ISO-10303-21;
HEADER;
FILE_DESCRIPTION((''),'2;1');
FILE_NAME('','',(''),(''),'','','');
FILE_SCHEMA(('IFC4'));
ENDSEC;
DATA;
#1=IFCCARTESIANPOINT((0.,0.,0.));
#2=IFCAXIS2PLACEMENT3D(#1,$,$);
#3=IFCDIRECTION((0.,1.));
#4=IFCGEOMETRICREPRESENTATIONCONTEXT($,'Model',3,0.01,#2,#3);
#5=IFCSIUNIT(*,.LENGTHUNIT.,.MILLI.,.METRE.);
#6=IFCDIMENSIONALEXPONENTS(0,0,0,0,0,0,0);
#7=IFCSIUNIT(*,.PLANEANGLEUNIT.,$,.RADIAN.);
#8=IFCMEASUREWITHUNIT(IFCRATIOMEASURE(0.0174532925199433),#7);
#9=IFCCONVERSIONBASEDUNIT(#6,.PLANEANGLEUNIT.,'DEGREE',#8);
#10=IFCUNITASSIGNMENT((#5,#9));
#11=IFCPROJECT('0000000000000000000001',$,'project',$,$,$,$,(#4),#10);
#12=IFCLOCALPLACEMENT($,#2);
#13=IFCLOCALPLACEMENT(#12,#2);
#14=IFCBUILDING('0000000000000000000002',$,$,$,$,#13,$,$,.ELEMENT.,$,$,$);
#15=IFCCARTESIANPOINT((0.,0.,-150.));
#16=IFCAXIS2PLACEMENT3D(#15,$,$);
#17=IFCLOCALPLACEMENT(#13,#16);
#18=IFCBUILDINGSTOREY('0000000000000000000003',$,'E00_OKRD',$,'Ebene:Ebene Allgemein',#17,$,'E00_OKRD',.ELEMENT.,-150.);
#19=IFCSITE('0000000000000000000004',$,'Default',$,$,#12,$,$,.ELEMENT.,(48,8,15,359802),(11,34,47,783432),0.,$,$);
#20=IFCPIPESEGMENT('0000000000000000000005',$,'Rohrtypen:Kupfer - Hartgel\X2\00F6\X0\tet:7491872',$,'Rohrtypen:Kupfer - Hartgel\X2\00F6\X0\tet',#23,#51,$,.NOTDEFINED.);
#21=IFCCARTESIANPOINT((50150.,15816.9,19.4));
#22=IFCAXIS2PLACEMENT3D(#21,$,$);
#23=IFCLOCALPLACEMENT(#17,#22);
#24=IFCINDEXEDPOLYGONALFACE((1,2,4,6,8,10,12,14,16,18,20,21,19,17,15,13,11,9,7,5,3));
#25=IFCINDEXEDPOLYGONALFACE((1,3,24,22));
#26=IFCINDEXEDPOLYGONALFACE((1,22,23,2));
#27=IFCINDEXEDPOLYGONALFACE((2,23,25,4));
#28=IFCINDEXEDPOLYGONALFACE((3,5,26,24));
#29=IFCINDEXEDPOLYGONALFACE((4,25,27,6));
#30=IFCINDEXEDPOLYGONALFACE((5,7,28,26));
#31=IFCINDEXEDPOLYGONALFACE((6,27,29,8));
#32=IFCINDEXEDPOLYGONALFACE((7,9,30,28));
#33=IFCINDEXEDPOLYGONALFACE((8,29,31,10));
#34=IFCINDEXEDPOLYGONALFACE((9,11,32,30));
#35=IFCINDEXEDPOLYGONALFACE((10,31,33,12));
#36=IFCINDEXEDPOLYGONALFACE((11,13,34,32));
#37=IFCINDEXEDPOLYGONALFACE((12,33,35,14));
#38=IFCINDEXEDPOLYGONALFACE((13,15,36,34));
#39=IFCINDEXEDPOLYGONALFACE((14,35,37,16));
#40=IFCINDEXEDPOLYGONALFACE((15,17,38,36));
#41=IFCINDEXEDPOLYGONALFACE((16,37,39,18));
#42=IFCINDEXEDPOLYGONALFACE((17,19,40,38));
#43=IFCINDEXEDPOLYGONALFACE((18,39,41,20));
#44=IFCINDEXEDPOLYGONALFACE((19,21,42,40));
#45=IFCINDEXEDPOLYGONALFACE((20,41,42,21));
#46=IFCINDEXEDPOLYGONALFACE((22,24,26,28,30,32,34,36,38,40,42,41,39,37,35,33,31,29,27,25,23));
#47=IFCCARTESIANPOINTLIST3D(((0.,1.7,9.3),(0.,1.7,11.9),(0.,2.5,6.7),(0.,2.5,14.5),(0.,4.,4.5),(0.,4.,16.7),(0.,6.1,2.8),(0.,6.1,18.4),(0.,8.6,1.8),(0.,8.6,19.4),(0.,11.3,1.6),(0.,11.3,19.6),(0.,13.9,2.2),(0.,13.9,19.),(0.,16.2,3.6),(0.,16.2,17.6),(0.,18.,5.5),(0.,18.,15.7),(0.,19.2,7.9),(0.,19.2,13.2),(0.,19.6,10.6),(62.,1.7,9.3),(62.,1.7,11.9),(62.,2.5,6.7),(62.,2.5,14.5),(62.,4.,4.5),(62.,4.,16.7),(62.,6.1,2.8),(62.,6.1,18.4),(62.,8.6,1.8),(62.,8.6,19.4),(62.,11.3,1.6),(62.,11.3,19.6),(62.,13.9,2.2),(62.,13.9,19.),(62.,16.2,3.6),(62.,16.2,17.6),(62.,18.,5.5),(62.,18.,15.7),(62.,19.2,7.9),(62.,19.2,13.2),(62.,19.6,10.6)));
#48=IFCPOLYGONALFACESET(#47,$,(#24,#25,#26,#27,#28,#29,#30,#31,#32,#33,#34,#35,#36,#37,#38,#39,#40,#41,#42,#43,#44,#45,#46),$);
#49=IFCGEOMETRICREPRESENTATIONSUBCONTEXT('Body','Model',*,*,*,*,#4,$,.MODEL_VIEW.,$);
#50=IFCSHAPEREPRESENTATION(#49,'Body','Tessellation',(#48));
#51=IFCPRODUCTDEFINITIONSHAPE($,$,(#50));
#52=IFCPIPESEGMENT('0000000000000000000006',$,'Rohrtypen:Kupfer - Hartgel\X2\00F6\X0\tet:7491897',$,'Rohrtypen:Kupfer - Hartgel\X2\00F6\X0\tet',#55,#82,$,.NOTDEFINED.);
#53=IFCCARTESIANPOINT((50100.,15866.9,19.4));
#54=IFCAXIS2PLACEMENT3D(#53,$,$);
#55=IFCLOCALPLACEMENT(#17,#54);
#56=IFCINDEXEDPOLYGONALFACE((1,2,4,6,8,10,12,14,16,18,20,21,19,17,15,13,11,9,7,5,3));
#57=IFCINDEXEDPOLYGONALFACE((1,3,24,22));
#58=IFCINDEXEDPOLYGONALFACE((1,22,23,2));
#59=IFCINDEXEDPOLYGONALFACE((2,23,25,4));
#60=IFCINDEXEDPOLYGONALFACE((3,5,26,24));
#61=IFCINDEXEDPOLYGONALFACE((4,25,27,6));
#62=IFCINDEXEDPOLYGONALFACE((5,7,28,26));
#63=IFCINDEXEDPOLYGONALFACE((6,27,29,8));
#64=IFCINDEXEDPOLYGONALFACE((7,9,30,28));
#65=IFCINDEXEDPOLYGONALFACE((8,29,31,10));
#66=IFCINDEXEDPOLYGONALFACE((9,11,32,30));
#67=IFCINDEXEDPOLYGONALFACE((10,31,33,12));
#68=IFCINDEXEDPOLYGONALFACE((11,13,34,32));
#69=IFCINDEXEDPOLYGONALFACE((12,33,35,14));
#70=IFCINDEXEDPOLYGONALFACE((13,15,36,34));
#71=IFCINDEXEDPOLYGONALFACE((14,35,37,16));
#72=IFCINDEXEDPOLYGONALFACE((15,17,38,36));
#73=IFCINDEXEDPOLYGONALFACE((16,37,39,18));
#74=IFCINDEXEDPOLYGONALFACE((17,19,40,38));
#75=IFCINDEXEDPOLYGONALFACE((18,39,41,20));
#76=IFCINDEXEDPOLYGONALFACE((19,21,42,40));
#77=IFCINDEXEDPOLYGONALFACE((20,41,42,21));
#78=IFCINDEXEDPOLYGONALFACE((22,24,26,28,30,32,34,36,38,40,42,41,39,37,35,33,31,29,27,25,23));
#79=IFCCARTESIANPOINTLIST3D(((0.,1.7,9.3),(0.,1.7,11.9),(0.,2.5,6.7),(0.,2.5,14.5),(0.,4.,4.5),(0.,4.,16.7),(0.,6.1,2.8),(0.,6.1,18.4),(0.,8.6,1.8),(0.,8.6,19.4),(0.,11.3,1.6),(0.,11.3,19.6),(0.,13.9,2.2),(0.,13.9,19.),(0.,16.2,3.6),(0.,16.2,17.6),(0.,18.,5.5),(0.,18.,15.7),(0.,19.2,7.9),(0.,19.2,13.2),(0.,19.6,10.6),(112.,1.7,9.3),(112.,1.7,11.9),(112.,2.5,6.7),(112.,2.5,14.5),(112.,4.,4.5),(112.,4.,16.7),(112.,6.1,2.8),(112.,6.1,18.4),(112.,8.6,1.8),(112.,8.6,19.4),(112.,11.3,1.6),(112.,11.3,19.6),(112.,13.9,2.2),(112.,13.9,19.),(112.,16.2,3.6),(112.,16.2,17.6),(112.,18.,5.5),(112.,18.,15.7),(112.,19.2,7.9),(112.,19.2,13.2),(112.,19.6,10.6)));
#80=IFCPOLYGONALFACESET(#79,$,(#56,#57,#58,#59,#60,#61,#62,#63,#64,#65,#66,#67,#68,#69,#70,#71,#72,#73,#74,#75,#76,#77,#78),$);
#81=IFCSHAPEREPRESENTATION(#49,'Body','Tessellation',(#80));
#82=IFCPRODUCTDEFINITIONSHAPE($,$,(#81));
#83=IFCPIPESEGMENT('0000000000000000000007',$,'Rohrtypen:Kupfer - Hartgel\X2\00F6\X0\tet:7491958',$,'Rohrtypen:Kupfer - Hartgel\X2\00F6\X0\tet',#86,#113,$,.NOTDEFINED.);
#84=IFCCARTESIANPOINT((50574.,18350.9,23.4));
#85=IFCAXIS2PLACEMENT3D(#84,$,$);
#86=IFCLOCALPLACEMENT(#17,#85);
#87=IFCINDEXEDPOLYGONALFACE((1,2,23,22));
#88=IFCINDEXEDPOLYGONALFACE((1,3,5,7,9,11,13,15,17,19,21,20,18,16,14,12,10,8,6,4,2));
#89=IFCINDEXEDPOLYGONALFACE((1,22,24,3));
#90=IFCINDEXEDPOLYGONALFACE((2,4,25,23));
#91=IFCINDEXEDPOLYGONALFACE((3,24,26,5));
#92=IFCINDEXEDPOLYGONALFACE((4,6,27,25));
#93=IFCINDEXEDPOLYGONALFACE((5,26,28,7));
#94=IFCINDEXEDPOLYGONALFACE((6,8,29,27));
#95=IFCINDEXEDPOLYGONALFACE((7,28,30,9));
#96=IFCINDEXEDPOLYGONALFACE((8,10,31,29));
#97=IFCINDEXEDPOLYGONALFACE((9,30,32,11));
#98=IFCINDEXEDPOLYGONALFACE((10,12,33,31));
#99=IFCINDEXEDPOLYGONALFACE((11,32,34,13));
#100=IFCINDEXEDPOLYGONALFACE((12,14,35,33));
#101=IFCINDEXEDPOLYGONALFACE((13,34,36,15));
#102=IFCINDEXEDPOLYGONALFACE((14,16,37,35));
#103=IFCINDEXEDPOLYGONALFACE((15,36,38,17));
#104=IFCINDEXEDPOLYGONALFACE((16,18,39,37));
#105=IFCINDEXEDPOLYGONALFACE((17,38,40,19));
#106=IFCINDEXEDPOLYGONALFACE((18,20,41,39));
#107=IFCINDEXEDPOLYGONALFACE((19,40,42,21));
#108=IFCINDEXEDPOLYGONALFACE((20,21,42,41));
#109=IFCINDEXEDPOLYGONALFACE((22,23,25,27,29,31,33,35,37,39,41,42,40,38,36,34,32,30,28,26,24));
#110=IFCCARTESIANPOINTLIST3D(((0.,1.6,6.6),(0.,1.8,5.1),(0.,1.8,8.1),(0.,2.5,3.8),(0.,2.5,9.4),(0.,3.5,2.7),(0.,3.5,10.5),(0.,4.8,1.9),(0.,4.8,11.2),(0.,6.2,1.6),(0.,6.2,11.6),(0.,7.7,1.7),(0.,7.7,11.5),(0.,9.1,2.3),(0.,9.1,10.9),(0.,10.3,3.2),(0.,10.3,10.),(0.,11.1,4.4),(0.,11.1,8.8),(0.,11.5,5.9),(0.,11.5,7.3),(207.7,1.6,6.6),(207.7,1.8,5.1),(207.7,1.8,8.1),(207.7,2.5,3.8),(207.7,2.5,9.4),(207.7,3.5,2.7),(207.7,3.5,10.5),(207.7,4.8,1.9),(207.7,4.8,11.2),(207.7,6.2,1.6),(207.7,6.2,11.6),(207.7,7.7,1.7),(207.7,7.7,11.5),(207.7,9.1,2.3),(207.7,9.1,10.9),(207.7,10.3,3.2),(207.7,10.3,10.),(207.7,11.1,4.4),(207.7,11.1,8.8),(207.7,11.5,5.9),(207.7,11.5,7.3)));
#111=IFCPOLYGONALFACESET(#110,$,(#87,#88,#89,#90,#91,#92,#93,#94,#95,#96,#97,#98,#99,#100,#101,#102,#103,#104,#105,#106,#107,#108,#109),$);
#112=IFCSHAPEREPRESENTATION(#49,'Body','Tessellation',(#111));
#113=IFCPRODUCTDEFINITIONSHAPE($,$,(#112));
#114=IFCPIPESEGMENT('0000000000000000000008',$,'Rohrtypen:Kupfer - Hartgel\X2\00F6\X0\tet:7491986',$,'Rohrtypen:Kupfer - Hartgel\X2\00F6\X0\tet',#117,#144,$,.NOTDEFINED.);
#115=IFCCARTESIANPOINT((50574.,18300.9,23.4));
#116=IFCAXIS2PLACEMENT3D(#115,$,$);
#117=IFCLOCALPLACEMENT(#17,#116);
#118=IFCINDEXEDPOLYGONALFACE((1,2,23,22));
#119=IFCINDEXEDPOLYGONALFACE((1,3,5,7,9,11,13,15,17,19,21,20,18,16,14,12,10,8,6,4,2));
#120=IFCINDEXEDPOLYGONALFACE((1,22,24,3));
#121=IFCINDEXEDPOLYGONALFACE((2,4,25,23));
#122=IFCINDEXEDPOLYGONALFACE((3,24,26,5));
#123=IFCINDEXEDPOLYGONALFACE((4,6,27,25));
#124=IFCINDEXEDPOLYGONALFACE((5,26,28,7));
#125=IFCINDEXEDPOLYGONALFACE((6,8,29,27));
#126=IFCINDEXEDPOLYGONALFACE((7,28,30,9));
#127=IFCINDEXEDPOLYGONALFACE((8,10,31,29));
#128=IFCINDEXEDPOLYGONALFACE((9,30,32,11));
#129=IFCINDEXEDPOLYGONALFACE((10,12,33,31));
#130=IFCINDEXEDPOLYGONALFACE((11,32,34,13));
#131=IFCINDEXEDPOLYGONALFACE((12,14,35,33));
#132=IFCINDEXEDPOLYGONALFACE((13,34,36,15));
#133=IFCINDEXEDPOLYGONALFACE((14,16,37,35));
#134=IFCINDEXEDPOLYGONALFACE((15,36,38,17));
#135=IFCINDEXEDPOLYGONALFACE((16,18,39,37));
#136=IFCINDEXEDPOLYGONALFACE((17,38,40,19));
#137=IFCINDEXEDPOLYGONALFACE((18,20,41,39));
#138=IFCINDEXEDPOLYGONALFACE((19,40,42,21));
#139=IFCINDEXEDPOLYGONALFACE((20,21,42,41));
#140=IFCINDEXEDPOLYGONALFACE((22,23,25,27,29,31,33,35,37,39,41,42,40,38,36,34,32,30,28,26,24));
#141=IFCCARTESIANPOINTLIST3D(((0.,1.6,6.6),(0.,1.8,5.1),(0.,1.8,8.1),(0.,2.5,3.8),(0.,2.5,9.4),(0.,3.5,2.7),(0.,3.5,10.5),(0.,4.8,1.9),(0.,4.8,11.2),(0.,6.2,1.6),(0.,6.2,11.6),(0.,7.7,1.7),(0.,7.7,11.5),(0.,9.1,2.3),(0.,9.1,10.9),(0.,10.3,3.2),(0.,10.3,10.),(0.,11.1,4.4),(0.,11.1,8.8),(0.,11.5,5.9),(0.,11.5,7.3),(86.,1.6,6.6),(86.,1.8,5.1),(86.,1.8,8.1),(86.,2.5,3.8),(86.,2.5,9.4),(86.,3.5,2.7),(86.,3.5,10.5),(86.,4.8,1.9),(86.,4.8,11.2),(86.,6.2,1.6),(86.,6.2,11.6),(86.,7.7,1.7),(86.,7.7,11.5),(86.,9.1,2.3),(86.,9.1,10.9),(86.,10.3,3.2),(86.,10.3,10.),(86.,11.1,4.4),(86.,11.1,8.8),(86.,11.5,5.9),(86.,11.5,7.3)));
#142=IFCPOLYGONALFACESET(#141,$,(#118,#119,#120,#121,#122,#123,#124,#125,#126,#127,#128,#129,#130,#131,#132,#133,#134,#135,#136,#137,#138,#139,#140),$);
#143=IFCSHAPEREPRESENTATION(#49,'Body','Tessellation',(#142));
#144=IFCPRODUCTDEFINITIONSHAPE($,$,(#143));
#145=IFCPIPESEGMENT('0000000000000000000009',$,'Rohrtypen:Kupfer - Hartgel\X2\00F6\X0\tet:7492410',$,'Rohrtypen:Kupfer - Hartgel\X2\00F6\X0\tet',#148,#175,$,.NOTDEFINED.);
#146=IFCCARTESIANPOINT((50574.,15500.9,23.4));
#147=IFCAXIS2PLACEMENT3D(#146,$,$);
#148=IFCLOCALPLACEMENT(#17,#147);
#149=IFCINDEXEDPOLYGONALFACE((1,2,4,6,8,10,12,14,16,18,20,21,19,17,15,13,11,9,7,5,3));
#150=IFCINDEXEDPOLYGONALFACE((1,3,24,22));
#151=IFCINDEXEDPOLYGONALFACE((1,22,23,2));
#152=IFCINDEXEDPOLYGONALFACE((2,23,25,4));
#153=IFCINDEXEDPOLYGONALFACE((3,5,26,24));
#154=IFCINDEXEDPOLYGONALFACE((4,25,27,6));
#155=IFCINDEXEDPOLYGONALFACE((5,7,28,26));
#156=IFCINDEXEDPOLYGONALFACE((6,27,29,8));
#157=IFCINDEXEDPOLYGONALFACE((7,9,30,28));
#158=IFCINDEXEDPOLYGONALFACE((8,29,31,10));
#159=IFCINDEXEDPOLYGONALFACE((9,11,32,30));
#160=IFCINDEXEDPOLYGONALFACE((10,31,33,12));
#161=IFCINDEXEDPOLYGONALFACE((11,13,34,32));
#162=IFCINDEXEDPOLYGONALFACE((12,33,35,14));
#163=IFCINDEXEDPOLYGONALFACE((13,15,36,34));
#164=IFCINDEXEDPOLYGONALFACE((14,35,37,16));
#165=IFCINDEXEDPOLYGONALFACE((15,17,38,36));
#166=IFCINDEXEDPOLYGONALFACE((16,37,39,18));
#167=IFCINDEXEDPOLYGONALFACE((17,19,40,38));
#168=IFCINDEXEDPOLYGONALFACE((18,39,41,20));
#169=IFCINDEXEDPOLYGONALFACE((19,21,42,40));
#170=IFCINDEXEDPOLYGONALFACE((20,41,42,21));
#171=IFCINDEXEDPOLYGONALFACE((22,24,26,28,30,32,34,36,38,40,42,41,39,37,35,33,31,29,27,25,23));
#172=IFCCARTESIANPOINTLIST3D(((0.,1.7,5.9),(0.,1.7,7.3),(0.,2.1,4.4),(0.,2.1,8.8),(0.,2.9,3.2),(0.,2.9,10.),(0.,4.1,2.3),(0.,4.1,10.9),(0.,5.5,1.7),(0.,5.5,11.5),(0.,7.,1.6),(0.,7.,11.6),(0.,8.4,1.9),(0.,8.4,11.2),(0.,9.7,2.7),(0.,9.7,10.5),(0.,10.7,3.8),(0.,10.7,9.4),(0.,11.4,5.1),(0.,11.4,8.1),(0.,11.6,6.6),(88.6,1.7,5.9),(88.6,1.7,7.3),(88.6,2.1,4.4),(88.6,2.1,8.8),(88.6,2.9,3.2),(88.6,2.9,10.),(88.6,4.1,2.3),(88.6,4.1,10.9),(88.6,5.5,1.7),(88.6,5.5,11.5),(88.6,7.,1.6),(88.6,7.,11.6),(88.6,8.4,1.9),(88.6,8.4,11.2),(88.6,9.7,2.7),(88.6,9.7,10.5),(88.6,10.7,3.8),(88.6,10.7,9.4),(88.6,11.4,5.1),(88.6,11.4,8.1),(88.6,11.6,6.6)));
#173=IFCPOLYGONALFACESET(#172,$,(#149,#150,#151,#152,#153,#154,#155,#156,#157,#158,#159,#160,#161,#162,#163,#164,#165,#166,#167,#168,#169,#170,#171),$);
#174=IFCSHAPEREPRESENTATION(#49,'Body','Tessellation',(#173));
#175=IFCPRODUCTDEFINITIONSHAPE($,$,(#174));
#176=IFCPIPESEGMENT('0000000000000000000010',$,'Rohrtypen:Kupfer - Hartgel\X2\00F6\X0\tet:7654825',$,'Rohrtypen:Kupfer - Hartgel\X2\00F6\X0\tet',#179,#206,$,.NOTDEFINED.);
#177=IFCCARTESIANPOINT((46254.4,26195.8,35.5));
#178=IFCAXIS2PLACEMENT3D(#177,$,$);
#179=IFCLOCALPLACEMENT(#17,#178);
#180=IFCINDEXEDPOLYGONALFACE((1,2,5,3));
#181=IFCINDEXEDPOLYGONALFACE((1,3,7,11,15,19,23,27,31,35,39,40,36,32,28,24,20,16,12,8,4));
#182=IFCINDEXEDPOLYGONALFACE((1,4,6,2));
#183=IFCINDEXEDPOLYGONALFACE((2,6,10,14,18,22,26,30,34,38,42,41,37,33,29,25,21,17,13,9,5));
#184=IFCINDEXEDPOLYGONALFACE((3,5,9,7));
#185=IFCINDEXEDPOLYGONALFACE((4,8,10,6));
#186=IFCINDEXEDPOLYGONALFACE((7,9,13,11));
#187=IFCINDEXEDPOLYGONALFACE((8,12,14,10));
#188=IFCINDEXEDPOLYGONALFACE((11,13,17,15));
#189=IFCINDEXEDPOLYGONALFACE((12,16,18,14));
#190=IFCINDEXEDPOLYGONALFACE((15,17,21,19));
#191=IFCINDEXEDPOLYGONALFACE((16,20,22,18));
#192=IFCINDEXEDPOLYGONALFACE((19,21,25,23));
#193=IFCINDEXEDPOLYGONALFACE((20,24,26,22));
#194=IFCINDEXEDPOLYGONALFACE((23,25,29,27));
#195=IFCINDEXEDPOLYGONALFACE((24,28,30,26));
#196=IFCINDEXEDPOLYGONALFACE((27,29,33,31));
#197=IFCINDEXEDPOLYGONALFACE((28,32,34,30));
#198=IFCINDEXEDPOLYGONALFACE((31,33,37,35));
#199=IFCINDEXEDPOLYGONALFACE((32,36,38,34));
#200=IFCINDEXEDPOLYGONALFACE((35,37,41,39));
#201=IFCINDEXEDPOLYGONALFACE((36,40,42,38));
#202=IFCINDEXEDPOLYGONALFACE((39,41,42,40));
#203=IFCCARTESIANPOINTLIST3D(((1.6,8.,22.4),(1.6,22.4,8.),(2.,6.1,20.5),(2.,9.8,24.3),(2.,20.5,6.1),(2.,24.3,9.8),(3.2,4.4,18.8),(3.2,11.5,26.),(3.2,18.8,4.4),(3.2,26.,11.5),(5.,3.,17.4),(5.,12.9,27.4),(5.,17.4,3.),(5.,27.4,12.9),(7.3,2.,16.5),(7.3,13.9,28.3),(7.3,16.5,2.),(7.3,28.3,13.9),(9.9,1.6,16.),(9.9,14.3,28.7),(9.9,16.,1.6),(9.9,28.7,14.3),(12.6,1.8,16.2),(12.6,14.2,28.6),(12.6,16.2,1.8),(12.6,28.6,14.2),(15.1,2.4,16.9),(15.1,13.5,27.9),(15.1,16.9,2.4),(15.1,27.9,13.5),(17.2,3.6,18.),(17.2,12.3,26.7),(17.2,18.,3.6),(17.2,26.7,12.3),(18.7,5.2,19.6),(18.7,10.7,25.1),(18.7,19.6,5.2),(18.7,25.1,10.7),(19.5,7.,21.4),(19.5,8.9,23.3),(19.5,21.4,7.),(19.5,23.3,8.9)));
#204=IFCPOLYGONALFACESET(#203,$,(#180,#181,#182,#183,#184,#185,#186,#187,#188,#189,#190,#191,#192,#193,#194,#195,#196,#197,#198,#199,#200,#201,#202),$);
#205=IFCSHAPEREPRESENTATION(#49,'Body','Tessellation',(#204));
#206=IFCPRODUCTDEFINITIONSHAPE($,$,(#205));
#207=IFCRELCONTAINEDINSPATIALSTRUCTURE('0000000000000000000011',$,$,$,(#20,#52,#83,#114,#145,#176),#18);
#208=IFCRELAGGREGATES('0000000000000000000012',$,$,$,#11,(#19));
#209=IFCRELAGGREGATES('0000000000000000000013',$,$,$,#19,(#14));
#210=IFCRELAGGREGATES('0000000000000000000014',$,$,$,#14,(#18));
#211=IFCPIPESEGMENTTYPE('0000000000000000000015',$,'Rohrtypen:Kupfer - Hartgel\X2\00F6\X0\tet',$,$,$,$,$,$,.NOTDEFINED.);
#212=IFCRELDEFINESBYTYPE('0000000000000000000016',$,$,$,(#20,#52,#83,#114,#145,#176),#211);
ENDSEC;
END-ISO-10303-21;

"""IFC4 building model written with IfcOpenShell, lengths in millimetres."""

from ifc_helpers import new_model, entity, si_unit, converted_unit, direction, frame, frame_2d, origin, origin_2d_with_axis, place, context, subcontext, project, spatial, circle, extrude, type_object, element, save


model = new_model("IFC4")

# Units and contexts
model_context = context("Model", 3, precision=0.01, world=origin(), true_north=direction((0.0, 1.0)))
body_context = subcontext(model_context, "Body", "Model", "MODEL_VIEW")
ifc_project = project(units=[si_unit("LENGTHUNIT", "METRE", prefix="MILLI"), converted_unit("PLANEANGLEUNIT", "DEGREE", entity("IfcRatioMeasure", 0.0174532925199433), si_unit("PLANEANGLEUNIT", "RADIAN"), dimensions=[0, 0, 0, 0, 0, 0, 0])], contexts=[model_context])

# Site, building, storey
site_placement = place(None, origin())
site = spatial("IfcSite", under=ifc_project, at=site_placement, Name="Default", CompositionType="ELEMENT", RefLatitude=(48, 8, 15, 359802), RefLongitude=(11, 34, 47, 783432), RefElevation=0.0)
building_placement = place(site_placement, origin())
building = spatial("IfcBuilding", under=site, at=building_placement, CompositionType="ELEMENT")
storey_placement = place(building_placement, frame((0.0, 0.0, -150.0)))
storey = spatial("IfcBuildingStorey", under=building, at=storey_placement, Name="E00_OKRD", ObjectType="Ebene:Ebene Allgemein", LongName="E00_OKRD", CompositionType="ELEMENT", Elevation=-150.0)

# Pipe segments
pipe_segment_type = type_object("IfcPipeSegmentType", Name="Rohrtypen:Kupfer - Hartgelötet", PredefinedType="NOTDEFINED")
pipe_segment_1_placement = place(storey_placement, frame((50150.0, 15816.9, 19.4)))
element("IfcPipeSegment", 1, at=pipe_segment_1_placement, inside=storey, type_object=pipe_segment_type, Name="Rohrtypen:Kupfer - Hartgelötet:7491872", ObjectType="Rohrtypen:Kupfer - Hartgelötet", PredefinedType="NOTDEFINED", context=body_context, shape_type="SweptSolid", body=[
    extrude(circle(Radius=9.0, at=frame_2d((0.0, 0.0), x_axis=(1.0, 0.0))), frame((0.0, 10.6, 10.6), z_axis=(1.0, 0.0, 0.0), x_axis=(0.0, 1.0, 0.0)), (0.0, 0.0, 1.0), 62.0),
])
pipe_segment_2_placement = place(storey_placement, frame((50100.0, 15866.9, 19.4)))
element("IfcPipeSegment", 2, at=pipe_segment_2_placement, inside=storey, type_object=pipe_segment_type, Name="Rohrtypen:Kupfer - Hartgelötet:7491897", ObjectType="Rohrtypen:Kupfer - Hartgelötet", PredefinedType="NOTDEFINED", context=body_context, shape_type="SweptSolid", body=[
    extrude(circle(Radius=9.0, at=frame_2d((0.0, 0.0), x_axis=(1.0, 0.0))), frame((0.0, 10.6, 10.6), z_axis=(1.0, 0.0, 0.0), x_axis=(0.0, 1.0, 0.0)), (0.0, 0.0, 1.0), 112.0),
])
pipe_segment_3_placement = place(storey_placement, frame((50574.0, 18350.9, 23.4)))
element("IfcPipeSegment", 3, at=pipe_segment_3_placement, inside=storey, type_object=pipe_segment_type, Name="Rohrtypen:Kupfer - Hartgelötet:7491958", ObjectType="Rohrtypen:Kupfer - Hartgelötet", PredefinedType="NOTDEFINED", context=body_context, shape_type="SweptSolid", body=[
    extrude(circle(Radius=5.0, at=frame_2d((0.0, 0.0), x_axis=(1.0, 0.0))), frame((0.0, 6.6, 6.6), z_axis=(1.0, 0.0, 0.0), x_axis=(0.0, -1.0, 0.0)), (0.0, 0.0, 1.0), 207.7),
])
pipe_segment_4_placement = place(storey_placement, frame((50574.0, 18300.9, 23.4)))
element("IfcPipeSegment", 4, at=pipe_segment_4_placement, inside=storey, type_object=pipe_segment_type, Name="Rohrtypen:Kupfer - Hartgelötet:7491986", ObjectType="Rohrtypen:Kupfer - Hartgelötet", PredefinedType="NOTDEFINED", context=body_context, shape_type="SweptSolid", body=[
    extrude(circle(Radius=5.0, at=origin_2d_with_axis()), frame((0.0, 6.6, 6.6), z_axis=(1.0, 0.0, 0.0), x_axis=(0.0, -1.0, 0.0)), (0.0, 0.0, 1.0), 86.0),
])
pipe_segment_5_placement = place(storey_placement, frame((50574.0, 15500.9, 23.4)))
element("IfcPipeSegment", 5, at=pipe_segment_5_placement, inside=storey, type_object=pipe_segment_type, Name="Rohrtypen:Kupfer - Hartgelötet:7492410", ObjectType="Rohrtypen:Kupfer - Hartgelötet", PredefinedType="NOTDEFINED", context=body_context, shape_type="SweptSolid", body=[
    extrude(circle(Radius=5.0, at=origin_2d_with_axis()), frame((0.0, 6.6, 6.6), z_axis=(1.0, 0.0, 0.0), x_axis=(0.0, 1.0, 0.0)), (0.0, 0.0, 1.0), 88.6),
])
pipe_segment_6_placement = place(storey_placement, frame((46254.4, 26195.8, 35.5)))
element("IfcPipeSegment", 6, at=pipe_segment_6_placement, inside=storey, type_object=pipe_segment_type, Name="Rohrtypen:Kupfer - Hartgelötet:7654825", ObjectType="Rohrtypen:Kupfer - Hartgelötet", PredefinedType="NOTDEFINED", context=body_context, shape_type="SweptSolid", body=[
    extrude(circle(Radius=9.0, at=frame_2d((0.0, 0.0), x_axis=(1.0, 0.0))), frame((10.6, 8.0, 22.4), z_axis=(0.0, 0.707107, -0.707107), x_axis=(-1.0, 0.0, 0.0)), (0.0, 0.0, 1.0), 20.4),
])

save(model, "model.ifc")
